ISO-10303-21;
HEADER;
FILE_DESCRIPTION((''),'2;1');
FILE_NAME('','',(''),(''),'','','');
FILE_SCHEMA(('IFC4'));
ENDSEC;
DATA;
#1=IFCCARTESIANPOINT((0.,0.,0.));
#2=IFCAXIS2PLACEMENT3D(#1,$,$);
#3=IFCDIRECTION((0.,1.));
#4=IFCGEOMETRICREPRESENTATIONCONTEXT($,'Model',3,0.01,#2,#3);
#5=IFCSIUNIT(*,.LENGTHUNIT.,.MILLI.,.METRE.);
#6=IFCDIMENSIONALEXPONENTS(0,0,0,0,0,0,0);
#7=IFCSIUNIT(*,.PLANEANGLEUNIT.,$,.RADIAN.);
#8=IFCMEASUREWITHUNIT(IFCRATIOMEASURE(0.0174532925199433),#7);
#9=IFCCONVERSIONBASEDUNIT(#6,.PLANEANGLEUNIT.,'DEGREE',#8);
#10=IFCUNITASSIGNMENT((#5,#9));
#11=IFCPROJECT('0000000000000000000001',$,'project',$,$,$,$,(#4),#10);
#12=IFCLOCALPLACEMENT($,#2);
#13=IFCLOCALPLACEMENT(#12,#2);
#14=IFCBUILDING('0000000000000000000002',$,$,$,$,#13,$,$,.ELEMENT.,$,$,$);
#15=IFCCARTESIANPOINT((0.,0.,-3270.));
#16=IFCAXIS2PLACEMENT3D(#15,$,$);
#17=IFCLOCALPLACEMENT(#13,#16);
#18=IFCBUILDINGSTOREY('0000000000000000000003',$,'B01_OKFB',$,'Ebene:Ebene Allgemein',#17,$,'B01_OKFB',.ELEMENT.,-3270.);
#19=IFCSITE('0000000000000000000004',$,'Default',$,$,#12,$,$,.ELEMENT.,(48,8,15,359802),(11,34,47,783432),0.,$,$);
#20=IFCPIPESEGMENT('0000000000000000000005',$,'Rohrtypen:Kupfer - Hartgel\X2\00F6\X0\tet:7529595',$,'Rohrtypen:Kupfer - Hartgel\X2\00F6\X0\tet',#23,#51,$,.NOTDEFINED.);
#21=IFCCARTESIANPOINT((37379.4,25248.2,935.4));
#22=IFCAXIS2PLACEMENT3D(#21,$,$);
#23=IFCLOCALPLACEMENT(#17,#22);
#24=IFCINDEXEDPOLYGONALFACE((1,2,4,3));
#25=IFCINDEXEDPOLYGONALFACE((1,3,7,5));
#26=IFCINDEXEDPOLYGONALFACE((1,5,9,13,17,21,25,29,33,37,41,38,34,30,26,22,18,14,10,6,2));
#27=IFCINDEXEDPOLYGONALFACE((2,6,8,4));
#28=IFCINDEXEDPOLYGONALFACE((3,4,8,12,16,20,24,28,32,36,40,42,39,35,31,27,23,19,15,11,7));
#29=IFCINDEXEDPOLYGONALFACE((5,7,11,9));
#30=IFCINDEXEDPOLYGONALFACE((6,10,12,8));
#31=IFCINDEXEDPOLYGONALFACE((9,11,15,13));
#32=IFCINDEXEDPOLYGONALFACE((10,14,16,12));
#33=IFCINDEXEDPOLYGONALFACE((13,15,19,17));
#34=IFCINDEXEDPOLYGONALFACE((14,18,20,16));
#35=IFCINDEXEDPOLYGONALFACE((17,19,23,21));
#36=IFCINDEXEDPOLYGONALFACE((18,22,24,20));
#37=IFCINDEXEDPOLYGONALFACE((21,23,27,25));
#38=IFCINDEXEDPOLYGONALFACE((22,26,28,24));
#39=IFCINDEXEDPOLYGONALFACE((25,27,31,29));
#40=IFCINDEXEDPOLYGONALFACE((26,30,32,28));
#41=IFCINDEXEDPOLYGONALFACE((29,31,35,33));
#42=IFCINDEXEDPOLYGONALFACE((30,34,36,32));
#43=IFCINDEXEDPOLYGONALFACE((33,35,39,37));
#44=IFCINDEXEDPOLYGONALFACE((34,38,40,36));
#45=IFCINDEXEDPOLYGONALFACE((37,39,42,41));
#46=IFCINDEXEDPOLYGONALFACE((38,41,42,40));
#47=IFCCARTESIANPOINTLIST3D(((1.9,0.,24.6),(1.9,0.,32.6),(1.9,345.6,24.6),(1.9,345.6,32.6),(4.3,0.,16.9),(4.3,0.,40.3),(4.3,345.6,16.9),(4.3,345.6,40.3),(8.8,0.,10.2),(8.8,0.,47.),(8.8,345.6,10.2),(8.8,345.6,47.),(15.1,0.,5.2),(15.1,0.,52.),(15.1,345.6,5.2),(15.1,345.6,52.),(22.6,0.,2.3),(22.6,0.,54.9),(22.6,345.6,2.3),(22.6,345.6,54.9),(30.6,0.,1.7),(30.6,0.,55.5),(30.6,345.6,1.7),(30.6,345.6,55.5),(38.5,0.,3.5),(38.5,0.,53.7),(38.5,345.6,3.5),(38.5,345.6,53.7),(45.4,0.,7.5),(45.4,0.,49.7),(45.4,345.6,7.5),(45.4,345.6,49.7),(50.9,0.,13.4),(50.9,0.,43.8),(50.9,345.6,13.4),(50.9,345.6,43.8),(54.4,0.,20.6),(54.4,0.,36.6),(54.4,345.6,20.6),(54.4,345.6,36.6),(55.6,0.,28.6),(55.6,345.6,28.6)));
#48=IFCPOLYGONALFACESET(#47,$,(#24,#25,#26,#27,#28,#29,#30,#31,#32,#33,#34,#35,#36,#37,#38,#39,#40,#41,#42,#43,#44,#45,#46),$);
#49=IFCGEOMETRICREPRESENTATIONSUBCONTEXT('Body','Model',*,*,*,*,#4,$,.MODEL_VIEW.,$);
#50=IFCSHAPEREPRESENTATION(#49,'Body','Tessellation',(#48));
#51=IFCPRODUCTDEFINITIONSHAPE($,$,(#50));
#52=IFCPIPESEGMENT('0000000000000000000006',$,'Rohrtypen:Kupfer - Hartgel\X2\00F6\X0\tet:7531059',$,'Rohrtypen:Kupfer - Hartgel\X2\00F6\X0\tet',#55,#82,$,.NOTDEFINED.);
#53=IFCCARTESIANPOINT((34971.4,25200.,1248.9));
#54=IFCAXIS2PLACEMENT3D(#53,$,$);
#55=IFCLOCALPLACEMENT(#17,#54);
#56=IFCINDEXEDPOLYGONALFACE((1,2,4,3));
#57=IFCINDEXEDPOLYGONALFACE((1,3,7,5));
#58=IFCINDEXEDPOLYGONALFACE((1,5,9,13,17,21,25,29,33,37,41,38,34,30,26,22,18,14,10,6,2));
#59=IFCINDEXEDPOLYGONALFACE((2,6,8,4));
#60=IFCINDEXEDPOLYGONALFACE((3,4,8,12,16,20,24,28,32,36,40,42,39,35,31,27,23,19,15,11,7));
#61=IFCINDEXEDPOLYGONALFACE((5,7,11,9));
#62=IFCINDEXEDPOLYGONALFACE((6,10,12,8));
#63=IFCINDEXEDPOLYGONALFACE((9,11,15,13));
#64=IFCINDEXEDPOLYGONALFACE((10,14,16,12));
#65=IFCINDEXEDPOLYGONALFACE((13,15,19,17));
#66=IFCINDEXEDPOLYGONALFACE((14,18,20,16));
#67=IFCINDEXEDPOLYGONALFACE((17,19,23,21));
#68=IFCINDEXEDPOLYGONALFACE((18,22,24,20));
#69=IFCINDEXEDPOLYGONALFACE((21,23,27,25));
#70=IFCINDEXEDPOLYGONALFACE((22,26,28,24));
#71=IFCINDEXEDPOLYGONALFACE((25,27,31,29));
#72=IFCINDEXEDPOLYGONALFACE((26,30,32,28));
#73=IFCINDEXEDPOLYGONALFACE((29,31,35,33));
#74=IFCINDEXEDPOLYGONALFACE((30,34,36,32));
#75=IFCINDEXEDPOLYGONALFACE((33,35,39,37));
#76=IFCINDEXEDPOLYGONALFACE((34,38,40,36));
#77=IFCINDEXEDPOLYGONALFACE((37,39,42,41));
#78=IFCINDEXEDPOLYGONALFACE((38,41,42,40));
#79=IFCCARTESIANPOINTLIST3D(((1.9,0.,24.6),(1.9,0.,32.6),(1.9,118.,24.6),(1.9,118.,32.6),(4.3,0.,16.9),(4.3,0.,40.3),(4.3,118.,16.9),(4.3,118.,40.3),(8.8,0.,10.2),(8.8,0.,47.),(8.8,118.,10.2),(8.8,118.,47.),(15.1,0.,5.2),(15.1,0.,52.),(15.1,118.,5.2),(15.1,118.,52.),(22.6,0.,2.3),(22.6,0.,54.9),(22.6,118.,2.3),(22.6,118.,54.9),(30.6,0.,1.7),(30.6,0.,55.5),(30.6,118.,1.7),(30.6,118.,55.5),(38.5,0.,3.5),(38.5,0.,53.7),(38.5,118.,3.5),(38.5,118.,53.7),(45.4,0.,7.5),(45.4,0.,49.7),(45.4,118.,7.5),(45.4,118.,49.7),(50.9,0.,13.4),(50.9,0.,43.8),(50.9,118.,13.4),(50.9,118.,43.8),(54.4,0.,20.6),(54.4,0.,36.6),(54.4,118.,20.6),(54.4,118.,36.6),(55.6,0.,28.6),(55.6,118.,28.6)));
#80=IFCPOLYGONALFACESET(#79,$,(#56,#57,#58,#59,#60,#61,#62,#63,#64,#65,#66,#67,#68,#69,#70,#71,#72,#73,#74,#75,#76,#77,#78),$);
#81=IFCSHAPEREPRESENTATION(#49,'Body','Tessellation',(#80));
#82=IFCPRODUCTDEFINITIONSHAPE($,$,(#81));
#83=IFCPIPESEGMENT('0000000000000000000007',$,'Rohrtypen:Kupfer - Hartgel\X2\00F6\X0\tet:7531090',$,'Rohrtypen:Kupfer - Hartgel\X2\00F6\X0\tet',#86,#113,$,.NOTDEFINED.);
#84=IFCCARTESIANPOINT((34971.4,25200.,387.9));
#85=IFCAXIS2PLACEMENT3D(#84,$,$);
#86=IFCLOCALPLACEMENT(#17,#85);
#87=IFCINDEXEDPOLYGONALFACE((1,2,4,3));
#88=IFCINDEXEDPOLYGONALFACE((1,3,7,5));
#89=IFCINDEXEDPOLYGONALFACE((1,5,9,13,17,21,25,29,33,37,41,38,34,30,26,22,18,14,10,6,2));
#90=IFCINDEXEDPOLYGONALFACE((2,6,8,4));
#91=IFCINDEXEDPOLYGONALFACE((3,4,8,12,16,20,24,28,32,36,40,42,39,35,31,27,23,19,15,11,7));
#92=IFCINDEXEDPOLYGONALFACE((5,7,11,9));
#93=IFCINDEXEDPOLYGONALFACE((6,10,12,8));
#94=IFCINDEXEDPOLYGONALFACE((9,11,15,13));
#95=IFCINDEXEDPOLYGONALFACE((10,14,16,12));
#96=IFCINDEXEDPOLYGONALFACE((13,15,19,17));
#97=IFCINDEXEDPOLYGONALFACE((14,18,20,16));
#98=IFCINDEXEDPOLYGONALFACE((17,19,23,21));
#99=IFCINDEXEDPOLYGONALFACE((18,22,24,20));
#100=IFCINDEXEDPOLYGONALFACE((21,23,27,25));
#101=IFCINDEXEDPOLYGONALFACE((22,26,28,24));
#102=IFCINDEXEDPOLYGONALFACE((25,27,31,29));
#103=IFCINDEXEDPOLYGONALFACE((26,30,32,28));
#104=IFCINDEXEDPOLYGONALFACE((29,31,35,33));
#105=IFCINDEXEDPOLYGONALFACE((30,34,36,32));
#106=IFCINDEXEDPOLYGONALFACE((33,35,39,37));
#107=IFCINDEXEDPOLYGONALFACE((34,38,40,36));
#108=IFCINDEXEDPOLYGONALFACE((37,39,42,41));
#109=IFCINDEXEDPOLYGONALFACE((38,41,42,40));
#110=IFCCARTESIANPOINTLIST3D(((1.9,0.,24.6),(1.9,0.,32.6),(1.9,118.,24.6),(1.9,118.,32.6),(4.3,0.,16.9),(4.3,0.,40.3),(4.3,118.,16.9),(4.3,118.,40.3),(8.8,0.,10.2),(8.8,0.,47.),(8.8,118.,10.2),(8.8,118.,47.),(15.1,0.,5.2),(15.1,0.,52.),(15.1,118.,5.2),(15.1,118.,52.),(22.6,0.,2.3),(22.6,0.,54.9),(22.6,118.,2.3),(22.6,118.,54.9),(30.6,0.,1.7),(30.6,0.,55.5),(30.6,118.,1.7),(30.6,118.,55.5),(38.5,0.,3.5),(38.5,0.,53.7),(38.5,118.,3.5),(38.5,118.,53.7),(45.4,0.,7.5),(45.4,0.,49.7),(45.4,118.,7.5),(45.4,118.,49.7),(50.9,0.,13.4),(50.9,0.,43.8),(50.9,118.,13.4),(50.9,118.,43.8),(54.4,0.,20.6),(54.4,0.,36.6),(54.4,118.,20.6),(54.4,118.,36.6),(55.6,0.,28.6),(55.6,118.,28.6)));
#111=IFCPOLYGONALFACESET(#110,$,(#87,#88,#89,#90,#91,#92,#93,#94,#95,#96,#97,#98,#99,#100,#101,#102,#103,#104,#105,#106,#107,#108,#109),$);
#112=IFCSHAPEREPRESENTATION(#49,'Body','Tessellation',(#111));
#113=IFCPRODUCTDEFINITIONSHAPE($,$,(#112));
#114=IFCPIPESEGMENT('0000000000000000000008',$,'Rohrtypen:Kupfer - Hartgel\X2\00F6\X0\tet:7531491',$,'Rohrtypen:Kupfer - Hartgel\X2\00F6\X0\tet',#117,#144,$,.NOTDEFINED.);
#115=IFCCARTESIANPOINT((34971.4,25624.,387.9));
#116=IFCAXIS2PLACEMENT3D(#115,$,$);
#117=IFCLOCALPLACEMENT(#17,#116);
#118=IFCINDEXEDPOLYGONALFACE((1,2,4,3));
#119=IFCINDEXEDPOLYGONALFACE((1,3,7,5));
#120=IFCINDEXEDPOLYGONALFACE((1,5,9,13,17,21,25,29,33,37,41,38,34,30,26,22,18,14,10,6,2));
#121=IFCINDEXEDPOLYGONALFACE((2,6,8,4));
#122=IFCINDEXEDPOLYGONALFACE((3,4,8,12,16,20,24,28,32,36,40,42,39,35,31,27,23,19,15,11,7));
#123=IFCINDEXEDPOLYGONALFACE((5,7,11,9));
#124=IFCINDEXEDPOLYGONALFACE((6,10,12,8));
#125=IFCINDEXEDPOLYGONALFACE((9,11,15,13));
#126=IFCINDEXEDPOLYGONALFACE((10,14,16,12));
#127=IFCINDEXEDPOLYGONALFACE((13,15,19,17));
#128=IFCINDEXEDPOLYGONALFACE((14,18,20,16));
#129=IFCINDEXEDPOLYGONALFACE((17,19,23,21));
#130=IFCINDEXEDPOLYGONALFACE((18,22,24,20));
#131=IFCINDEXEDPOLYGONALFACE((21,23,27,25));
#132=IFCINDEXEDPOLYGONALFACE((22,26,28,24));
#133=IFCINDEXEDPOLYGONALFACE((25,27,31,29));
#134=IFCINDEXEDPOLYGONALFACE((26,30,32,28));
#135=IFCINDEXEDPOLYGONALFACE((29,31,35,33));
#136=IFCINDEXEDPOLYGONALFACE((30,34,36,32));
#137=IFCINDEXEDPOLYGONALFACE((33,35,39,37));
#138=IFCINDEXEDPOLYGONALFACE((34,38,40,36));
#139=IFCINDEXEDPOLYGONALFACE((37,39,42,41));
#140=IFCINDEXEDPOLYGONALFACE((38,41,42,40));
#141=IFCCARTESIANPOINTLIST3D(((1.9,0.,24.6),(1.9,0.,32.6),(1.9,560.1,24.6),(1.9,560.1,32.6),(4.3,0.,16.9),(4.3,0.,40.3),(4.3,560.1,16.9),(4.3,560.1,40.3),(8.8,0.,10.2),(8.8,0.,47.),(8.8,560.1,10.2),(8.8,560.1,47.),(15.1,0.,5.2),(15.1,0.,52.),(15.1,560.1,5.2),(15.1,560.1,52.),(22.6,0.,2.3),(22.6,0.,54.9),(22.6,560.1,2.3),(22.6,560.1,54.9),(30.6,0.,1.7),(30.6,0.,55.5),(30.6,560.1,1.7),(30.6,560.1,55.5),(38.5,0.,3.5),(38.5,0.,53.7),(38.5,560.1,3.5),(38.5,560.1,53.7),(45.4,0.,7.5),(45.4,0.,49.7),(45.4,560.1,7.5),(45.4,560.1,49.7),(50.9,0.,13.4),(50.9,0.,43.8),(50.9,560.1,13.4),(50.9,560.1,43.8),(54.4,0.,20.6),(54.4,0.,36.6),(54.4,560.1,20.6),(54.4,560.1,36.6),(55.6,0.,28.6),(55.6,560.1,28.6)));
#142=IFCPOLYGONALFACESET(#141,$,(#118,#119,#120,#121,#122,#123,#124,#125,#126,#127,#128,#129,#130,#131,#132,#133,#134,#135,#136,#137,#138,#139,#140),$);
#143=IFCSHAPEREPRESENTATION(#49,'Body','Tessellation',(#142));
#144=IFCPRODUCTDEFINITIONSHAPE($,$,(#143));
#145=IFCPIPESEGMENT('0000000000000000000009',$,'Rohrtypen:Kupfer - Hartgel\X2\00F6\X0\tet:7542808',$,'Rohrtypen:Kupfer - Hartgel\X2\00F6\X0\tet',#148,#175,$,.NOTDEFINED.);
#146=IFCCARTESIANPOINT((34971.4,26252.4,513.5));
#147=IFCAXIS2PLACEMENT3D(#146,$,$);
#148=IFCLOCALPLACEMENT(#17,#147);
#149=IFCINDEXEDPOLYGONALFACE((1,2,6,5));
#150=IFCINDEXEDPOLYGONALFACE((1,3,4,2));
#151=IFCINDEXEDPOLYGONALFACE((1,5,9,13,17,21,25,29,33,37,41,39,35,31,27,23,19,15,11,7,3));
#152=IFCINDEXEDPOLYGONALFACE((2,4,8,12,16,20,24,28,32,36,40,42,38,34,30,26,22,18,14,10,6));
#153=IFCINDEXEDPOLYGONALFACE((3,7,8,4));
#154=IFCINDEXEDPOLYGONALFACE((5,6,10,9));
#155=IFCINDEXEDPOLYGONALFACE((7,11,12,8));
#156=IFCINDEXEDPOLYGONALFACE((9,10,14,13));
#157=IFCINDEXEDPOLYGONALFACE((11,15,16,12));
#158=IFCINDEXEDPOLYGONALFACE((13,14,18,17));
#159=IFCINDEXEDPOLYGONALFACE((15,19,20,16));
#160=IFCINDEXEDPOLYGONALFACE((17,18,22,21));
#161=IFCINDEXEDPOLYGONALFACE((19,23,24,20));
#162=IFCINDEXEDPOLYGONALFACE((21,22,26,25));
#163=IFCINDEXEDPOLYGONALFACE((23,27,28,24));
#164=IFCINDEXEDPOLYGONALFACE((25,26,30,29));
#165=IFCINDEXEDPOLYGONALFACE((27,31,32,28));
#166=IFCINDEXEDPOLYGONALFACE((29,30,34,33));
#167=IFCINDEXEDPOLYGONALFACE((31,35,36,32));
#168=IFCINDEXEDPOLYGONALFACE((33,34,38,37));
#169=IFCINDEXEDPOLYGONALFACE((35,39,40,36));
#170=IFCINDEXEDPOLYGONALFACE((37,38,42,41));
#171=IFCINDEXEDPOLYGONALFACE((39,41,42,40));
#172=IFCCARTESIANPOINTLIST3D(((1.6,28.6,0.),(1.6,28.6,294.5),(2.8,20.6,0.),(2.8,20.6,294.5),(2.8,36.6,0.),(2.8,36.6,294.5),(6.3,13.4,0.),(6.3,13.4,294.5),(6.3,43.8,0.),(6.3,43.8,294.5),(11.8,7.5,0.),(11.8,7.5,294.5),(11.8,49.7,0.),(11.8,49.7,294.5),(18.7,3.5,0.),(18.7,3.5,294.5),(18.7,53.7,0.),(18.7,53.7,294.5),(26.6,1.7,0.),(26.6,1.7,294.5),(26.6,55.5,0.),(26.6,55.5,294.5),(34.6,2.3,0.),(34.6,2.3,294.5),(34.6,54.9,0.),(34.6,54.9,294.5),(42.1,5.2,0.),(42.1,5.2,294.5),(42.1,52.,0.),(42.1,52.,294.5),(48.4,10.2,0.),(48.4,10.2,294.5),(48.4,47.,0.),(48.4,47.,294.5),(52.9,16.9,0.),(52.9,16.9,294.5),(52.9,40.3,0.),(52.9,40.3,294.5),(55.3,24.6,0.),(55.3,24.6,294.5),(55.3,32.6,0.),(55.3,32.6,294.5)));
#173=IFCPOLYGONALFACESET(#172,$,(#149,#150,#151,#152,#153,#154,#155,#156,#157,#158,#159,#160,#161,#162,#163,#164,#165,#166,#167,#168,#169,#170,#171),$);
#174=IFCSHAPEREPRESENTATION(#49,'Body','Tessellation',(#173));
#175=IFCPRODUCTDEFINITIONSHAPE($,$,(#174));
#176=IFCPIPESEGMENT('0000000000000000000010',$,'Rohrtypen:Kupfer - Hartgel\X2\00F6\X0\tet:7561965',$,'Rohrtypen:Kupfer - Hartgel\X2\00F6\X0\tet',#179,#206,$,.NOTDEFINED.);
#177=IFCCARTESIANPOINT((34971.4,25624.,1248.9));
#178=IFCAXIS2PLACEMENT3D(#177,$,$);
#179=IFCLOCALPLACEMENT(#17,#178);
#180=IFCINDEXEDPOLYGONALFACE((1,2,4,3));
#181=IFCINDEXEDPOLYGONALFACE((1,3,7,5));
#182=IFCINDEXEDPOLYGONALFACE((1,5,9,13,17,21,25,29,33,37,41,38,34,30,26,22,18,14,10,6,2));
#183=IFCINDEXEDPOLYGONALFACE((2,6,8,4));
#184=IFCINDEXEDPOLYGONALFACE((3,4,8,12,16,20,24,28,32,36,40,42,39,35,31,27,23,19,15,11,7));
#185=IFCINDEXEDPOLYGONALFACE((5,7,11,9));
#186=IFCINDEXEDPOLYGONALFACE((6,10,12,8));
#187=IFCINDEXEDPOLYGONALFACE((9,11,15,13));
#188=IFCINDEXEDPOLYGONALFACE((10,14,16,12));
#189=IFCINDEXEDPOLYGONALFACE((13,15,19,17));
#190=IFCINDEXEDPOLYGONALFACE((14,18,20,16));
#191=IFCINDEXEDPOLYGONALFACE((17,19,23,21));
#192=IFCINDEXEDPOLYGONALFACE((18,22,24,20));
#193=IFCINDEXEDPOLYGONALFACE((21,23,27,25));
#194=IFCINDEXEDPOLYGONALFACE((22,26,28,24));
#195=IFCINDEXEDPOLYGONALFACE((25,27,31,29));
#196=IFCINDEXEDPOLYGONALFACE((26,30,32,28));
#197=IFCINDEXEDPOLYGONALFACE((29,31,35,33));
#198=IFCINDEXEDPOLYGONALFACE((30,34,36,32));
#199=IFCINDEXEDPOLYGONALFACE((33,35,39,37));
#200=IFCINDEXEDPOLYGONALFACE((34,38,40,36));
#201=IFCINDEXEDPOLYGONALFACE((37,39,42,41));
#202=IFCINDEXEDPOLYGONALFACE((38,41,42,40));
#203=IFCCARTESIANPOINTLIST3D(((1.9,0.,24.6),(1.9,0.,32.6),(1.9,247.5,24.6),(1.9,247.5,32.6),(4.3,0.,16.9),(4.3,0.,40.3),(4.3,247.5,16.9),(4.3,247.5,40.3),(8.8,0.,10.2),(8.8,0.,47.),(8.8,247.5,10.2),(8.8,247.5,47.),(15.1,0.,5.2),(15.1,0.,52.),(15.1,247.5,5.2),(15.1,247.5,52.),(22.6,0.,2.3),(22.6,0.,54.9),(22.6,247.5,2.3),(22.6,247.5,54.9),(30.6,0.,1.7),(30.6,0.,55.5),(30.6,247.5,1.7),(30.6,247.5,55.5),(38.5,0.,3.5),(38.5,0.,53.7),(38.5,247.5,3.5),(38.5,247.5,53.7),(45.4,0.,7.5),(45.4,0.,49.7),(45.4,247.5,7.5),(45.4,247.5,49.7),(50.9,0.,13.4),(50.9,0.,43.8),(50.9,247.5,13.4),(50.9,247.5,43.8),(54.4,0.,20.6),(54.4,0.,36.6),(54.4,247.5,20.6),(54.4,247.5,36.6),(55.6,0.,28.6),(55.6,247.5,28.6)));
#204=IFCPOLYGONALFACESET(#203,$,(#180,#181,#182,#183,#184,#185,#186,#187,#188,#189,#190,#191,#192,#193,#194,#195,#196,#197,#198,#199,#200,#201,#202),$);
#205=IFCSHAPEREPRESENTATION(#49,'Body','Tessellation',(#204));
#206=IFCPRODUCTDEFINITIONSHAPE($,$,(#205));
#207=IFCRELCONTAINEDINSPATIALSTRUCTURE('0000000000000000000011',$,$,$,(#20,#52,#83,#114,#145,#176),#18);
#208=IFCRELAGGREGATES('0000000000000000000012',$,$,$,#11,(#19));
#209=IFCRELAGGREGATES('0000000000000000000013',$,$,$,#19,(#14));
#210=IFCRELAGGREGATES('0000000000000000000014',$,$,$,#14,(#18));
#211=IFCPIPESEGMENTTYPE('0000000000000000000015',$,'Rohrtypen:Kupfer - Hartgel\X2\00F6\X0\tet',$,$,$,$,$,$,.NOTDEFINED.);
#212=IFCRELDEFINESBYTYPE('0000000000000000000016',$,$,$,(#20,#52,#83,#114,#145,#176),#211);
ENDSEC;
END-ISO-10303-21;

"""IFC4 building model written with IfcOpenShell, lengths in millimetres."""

from ifc_helpers import new_model, entity, si_unit, converted_unit, direction, frame, frame_2d, origin, origin_2d_with_axis, place, context, subcontext, project, spatial, circle, extrude, type_object, element, save


model = new_model("IFC4")

# Units and contexts
model_context = context("Model", 3, precision=0.01, world=origin(), true_north=direction((0.0, 1.0)))
body_context = subcontext(model_context, "Body", "Model", "MODEL_VIEW")
ifc_project = project(units=[si_unit("LENGTHUNIT", "METRE", prefix="MILLI"), converted_unit("PLANEANGLEUNIT", "DEGREE", entity("IfcRatioMeasure", 0.0174532925199433), si_unit("PLANEANGLEUNIT", "RADIAN"), dimensions=[0, 0, 0, 0, 0, 0, 0])], contexts=[model_context])

# Site, building, storey
site_placement = place(None, origin())
site = spatial("IfcSite", under=ifc_project, at=site_placement, Name="Default", CompositionType="ELEMENT", RefLatitude=(48, 8, 15, 359802), RefLongitude=(11, 34, 47, 783432), RefElevation=0.0)
building_placement = place(site_placement, origin())
building = spatial("IfcBuilding", under=site, at=building_placement, CompositionType="ELEMENT")
storey_placement = place(building_placement, frame((0.0, 0.0, -3270.0)))
storey = spatial("IfcBuildingStorey", under=building, at=storey_placement, Name="B01_OKFB", ObjectType="Ebene:Ebene Allgemein", LongName="B01_OKFB", CompositionType="ELEMENT", Elevation=-3270.0)

# Pipe segments
pipe_segment_type = type_object("IfcPipeSegmentType", Name="Rohrtypen:Kupfer - Hartgelötet", PredefinedType="NOTDEFINED")
pipe_segment_1_placement = place(storey_placement, frame((37379.4, 25248.2, 935.4)))
element("IfcPipeSegment", 1, at=pipe_segment_1_placement, inside=storey, type_object=pipe_segment_type, Name="Rohrtypen:Kupfer - Hartgelötet:7529595", ObjectType="Rohrtypen:Kupfer - Hartgelötet", PredefinedType="NOTDEFINED", context=body_context, shape_type="SweptSolid", body=[
    extrude(circle(Radius=27.0, at=frame_2d((0.0, 0.0), x_axis=(1.0, 0.0))), frame((28.6, 0.0, 28.6), z_axis=(0.0, 1.0, 0.0), x_axis=(1.0, 0.0, 0.0)), (0.0, 0.0, 1.0), 345.6),
])
for number, where, name in (
    (2, (34971.4, 25200.0, 1248.9), "Rohrtypen:Kupfer - Hartgelötet:7531059"),
    (3, (34971.4, 25200.0, 387.9), "Rohrtypen:Kupfer - Hartgelötet:7531090"),
):
    element("IfcPipeSegment", number, at=place(storey_placement, frame(where)), inside=storey, type_object=pipe_segment_type, Name=name, ObjectType="Rohrtypen:Kupfer - Hartgelötet", PredefinedType="NOTDEFINED", context=body_context, shape_type="SweptSolid", body=[
        extrude(circle(Radius=27.0, at=frame_2d((0.0, 0.0), x_axis=(1.0, 0.0))), frame((28.6, 0.0, 28.6), z_axis=(0.0, 1.0, 0.0), x_axis=(1.0, 0.0, 0.0)), (0.0, 0.0, 1.0), 118.0),
    ])
pipe_segment_2_placement = place(storey_placement, frame((34971.4, 25624.0, 387.9)))
element("IfcPipeSegment", 4, at=pipe_segment_2_placement, inside=storey, type_object=pipe_segment_type, Name="Rohrtypen:Kupfer - Hartgelötet:7531491", ObjectType="Rohrtypen:Kupfer - Hartgelötet", PredefinedType="NOTDEFINED", context=body_context, shape_type="SweptSolid", body=[
    extrude(circle(Radius=27.0, at=frame_2d((0.0, 0.0), x_axis=(1.0, 0.0))), frame((28.6, 0.0, 28.6), z_axis=(0.0, 1.0, 0.0), x_axis=(1.0, 0.0, 0.0)), (0.0, 0.0, 1.0), 560.1),
])
pipe_segment_3_placement = place(storey_placement, frame((34971.4, 26252.4, 513.5)))
element("IfcPipeSegment", 5, at=pipe_segment_3_placement, inside=storey, type_object=pipe_segment_type, Name="Rohrtypen:Kupfer - Hartgelötet:7542808", ObjectType="Rohrtypen:Kupfer - Hartgelötet", PredefinedType="NOTDEFINED", context=body_context, shape_type="SweptSolid", body=[
    extrude(circle(Radius=27.0, at=origin_2d_with_axis()), frame((28.6, 28.6, 0.0), z_axis=(0.0, 0.0, 1.0), x_axis=(-1.0, 0.0, 0.0)), (0.0, 0.0, 1.0), 294.5),
])
pipe_segment_4_placement = place(storey_placement, frame((34971.4, 25624.0, 1248.9)))
element("IfcPipeSegment", 6, at=pipe_segment_4_placement, inside=storey, type_object=pipe_segment_type, Name="Rohrtypen:Kupfer - Hartgelötet:7561965", ObjectType="Rohrtypen:Kupfer - Hartgelötet", PredefinedType="NOTDEFINED", context=body_context, shape_type="SweptSolid", body=[
    extrude(circle(Radius=27.0, at=frame_2d((0.0, 0.0), x_axis=(1.0, 0.0))), frame((28.6, 0.0, 28.6), z_axis=(0.0, 1.0, 0.0), x_axis=(1.0, 0.0, 0.0)), (0.0, 0.0, 1.0), 247.5),
])

save(model, "model.ifc")
